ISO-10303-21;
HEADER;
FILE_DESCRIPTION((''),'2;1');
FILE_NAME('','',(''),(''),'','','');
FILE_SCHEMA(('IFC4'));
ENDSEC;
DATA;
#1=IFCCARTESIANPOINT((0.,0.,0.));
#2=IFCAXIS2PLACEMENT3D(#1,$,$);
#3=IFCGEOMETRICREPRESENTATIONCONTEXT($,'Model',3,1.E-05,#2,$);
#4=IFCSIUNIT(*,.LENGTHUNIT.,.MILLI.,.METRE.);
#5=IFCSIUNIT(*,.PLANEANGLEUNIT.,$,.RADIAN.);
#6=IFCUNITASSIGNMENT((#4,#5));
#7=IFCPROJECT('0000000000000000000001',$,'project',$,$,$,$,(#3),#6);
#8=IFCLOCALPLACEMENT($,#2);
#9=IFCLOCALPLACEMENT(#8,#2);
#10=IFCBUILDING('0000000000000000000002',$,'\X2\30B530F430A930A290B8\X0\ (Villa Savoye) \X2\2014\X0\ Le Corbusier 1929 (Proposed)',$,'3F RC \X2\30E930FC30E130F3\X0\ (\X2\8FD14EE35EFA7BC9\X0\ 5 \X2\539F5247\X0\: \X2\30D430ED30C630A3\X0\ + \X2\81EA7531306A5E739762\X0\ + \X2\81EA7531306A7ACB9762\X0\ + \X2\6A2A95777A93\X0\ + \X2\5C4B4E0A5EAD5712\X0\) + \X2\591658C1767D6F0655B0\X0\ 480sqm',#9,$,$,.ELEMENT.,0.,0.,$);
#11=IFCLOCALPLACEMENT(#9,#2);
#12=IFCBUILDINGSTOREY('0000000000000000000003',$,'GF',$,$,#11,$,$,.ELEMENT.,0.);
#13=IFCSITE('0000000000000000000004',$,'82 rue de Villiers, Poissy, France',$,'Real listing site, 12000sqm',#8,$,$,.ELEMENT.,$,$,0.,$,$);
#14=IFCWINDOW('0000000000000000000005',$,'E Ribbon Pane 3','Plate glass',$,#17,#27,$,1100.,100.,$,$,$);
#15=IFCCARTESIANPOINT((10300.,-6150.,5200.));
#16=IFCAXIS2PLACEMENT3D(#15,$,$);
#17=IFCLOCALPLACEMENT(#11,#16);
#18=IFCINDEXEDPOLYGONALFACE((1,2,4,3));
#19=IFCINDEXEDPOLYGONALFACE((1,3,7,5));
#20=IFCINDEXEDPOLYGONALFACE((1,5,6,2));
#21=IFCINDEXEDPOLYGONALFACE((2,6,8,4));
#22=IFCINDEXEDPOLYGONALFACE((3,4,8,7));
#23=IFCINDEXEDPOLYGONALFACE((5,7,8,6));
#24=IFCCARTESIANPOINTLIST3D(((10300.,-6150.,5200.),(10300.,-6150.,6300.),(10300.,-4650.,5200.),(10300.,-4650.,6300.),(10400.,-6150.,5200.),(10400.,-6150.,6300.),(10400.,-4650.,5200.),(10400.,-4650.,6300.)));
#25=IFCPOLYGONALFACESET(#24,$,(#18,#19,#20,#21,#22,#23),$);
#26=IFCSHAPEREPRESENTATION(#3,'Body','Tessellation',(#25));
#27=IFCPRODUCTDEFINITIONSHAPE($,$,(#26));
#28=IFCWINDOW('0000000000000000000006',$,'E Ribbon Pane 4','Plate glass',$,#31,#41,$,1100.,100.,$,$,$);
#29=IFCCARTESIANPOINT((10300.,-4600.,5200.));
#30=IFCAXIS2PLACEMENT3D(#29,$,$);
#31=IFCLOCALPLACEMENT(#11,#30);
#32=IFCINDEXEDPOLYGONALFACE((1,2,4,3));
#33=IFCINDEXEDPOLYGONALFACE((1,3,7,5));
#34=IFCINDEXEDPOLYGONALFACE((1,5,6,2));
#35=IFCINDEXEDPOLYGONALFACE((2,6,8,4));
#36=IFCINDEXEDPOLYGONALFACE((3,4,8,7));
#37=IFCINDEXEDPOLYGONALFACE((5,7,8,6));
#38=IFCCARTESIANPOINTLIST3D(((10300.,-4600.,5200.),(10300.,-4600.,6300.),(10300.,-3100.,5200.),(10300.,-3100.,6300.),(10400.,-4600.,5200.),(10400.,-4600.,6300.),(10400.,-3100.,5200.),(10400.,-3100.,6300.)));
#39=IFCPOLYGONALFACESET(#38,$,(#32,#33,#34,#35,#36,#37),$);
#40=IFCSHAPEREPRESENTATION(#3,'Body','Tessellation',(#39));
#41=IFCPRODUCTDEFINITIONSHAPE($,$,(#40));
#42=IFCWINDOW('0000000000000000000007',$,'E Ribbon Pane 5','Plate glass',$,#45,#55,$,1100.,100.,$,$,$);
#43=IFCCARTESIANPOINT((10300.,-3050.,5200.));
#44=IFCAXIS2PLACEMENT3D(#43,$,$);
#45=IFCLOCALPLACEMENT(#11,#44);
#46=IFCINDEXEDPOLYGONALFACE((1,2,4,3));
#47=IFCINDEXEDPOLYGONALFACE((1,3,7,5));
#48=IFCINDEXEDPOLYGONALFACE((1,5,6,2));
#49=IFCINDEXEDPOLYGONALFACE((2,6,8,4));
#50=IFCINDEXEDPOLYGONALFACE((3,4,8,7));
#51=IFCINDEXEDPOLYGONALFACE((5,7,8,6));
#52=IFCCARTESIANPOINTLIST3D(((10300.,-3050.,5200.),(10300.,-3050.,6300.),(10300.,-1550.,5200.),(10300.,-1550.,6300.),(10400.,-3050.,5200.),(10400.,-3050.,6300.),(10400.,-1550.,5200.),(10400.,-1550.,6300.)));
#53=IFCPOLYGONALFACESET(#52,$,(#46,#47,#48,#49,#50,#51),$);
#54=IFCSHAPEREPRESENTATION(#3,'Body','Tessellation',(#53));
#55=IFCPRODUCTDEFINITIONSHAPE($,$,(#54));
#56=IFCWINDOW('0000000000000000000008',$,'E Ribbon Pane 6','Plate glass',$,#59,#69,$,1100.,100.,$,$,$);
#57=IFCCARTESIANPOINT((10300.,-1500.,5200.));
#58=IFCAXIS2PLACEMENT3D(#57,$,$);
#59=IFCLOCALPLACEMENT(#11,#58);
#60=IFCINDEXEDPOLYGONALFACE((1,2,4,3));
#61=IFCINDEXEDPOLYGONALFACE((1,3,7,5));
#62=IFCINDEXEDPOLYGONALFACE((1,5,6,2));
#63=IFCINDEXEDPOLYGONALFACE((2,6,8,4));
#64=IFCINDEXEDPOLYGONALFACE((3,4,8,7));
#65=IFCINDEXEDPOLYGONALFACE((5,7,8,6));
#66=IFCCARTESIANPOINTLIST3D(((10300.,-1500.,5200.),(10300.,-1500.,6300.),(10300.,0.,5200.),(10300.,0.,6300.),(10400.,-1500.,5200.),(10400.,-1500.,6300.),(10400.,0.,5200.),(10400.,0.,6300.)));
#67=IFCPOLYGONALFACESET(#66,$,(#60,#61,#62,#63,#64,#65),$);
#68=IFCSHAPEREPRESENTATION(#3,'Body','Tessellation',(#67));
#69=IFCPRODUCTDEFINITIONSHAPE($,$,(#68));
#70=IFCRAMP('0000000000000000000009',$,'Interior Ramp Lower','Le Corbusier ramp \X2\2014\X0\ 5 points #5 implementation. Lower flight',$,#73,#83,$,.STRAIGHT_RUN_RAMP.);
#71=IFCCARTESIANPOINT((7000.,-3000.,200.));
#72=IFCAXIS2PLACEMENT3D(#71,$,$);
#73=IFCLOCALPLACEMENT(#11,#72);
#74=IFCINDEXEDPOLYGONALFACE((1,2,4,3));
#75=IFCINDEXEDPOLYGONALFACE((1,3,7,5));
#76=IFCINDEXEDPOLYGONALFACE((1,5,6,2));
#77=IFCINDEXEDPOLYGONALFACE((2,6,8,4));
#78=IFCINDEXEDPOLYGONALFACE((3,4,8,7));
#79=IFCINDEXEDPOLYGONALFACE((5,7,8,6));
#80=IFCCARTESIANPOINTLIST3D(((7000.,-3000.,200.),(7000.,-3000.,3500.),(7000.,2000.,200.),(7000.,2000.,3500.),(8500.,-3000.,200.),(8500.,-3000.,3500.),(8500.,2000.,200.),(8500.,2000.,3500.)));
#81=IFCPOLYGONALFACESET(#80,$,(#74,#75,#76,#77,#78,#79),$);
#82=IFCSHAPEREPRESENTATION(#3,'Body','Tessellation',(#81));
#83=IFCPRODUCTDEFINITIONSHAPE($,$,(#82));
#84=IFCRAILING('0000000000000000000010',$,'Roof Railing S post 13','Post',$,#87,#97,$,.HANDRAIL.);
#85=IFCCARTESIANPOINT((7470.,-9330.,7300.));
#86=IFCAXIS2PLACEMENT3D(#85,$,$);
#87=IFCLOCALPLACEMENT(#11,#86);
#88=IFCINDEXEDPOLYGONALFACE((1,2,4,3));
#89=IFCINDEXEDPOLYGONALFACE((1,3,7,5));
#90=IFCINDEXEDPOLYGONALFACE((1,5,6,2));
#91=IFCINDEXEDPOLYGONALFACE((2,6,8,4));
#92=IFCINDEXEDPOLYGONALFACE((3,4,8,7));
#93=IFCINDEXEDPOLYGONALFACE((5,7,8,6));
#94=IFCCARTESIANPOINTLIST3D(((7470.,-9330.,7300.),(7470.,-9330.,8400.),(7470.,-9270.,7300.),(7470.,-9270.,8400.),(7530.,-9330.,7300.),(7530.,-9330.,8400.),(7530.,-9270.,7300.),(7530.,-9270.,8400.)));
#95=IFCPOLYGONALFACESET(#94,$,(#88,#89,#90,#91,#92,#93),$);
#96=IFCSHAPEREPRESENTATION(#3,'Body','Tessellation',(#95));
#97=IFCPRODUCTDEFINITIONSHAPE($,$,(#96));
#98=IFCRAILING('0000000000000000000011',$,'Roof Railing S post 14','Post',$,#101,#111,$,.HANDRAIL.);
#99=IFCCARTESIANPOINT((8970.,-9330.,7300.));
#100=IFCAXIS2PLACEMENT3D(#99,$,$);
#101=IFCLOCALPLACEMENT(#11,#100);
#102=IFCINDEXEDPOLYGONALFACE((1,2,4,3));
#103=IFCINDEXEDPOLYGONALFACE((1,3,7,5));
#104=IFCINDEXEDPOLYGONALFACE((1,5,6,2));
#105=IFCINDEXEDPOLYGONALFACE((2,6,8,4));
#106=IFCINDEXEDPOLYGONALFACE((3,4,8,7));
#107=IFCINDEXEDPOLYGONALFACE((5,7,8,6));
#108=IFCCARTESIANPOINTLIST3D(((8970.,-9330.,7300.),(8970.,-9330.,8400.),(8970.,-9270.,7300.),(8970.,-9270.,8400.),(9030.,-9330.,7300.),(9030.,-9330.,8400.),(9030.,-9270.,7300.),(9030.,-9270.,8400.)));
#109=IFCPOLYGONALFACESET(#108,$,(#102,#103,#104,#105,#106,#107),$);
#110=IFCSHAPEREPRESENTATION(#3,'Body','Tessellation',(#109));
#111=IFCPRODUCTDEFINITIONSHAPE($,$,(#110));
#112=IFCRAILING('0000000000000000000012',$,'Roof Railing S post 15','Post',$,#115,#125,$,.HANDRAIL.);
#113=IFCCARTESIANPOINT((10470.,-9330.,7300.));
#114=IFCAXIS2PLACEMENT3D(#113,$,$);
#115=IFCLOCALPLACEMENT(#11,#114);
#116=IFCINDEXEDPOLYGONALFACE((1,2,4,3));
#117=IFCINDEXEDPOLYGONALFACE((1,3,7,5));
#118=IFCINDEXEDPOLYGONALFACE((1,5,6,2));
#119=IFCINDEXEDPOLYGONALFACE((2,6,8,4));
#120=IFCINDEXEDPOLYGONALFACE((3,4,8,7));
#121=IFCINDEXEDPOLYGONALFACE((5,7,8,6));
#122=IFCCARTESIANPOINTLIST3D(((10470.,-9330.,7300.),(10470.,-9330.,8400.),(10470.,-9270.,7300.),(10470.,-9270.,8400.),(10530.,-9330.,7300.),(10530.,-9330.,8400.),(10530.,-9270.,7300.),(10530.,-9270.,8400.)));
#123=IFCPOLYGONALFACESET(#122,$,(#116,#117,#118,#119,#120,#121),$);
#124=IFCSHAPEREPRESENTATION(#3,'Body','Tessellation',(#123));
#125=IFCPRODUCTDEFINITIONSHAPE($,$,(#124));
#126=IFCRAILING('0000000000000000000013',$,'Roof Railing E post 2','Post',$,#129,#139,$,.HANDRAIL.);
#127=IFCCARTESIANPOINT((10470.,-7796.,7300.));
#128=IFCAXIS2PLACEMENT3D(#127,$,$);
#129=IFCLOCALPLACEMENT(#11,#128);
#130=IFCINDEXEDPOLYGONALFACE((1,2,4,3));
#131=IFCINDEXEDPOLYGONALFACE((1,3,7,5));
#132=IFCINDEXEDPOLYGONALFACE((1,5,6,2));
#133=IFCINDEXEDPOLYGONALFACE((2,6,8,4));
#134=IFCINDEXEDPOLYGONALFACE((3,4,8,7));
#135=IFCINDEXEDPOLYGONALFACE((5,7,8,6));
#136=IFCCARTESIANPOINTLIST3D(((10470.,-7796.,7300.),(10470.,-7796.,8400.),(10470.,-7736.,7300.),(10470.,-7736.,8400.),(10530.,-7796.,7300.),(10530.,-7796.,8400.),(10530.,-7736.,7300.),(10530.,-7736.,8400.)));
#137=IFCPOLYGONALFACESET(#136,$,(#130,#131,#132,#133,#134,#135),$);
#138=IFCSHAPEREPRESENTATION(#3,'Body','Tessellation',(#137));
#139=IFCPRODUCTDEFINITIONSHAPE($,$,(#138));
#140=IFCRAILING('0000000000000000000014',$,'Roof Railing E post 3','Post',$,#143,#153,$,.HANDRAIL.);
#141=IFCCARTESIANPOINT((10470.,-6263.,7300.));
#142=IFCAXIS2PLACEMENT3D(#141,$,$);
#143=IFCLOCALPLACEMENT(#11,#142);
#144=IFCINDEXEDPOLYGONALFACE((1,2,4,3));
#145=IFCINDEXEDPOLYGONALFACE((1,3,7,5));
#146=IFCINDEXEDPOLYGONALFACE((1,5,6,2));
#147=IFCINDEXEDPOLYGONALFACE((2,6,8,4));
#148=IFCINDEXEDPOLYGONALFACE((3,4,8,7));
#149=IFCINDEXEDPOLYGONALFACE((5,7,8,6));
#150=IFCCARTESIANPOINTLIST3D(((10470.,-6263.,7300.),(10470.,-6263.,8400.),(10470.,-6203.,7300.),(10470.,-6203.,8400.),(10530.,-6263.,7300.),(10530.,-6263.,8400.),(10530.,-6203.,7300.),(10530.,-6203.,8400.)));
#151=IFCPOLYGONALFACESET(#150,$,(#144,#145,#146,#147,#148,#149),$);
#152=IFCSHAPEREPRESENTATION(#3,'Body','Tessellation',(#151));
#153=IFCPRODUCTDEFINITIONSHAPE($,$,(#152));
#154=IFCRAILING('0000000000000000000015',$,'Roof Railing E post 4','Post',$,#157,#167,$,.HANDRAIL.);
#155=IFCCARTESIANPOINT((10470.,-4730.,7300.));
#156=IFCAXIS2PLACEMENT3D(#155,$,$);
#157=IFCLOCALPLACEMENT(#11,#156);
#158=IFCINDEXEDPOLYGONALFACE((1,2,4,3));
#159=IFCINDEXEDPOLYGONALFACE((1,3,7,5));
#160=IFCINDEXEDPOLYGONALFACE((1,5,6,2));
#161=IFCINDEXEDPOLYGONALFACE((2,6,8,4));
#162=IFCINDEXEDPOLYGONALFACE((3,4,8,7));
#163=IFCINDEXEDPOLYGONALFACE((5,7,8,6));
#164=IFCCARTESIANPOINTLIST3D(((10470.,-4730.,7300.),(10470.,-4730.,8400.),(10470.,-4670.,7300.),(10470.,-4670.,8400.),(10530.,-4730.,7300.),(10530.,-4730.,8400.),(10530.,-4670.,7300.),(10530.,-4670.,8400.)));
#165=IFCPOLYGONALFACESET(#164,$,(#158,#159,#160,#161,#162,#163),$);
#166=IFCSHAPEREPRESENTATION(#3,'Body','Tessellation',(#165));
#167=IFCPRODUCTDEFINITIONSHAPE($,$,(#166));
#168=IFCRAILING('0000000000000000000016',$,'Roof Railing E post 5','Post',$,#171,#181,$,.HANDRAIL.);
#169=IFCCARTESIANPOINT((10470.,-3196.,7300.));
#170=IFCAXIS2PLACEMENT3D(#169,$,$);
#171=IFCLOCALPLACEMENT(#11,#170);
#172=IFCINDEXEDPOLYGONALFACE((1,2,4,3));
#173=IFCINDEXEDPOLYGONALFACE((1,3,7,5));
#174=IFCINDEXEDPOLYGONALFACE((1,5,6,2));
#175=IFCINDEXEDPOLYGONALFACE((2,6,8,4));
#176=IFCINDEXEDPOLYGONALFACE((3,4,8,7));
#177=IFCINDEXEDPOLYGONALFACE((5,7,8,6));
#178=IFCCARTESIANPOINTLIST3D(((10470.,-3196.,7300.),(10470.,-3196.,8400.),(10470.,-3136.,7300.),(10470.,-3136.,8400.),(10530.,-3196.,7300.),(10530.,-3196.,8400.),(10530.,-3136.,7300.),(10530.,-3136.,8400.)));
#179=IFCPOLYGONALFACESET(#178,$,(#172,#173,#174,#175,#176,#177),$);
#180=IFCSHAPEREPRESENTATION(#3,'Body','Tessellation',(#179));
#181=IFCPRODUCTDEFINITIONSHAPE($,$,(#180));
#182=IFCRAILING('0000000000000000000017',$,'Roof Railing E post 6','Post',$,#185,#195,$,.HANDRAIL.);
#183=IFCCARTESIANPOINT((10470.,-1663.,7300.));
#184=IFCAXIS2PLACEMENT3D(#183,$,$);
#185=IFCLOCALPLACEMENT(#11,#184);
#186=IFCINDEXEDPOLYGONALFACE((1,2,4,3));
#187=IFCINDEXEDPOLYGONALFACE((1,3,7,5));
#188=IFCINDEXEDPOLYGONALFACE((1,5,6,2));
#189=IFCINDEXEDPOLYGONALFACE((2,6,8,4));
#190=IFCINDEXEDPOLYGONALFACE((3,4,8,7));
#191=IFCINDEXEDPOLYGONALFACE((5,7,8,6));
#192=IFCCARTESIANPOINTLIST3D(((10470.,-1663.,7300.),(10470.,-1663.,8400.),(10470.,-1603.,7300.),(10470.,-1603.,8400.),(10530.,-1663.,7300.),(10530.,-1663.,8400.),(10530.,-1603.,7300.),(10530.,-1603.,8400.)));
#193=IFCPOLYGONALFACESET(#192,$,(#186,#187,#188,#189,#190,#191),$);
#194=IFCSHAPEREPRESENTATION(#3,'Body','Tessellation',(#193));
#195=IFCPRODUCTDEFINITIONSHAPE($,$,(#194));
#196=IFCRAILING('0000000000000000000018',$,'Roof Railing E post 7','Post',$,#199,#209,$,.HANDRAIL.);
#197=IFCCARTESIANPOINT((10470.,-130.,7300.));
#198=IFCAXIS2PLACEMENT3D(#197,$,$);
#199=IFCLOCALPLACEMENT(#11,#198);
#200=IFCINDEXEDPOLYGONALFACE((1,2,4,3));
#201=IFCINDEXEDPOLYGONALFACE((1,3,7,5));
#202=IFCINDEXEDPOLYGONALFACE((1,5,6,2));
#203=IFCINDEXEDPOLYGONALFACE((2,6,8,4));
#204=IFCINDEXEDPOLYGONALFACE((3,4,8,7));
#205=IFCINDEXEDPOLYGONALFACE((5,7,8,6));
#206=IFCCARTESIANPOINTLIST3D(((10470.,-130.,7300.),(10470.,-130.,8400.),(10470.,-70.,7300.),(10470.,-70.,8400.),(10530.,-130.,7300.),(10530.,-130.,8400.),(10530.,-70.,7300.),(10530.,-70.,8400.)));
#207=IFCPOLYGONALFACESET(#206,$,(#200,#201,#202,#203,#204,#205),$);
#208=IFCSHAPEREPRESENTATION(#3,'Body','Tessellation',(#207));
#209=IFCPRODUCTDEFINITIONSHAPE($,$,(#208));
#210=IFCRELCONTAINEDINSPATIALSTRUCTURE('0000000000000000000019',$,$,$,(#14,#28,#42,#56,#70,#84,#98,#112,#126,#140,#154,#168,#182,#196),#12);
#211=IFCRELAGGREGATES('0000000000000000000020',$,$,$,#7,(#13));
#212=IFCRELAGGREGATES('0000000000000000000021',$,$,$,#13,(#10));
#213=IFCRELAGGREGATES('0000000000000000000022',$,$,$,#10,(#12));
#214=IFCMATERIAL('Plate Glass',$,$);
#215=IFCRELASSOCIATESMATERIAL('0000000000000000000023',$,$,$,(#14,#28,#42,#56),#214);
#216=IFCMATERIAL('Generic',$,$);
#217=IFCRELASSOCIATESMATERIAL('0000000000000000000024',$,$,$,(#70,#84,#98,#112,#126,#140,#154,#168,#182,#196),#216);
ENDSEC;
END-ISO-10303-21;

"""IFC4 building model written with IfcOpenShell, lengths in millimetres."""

from ifc_helpers import new_model, si_unit, frame, frame_2d, origin, place, context, project, spatial, rectangle, extrude, material, element, save


model = new_model("IFC4")

# Units and contexts
model_context = context("Model", 3, precision=1e-05, world=origin())
ifc_project = project(units=[si_unit("LENGTHUNIT", "METRE", prefix="MILLI"), si_unit("PLANEANGLEUNIT", "RADIAN")], contexts=[model_context])

# Site, building, storey
site_placement = place(None, origin())
site = spatial("IfcSite", under=ifc_project, at=site_placement, Name="82 rue de Villiers, Poissy, France", ObjectType="Real listing site, 12000sqm", CompositionType="ELEMENT", RefElevation=0.0)
building_placement = place(site_placement, origin())
building = spatial("IfcBuilding", under=site, at=building_placement, Name="サヴォア邸 (Villa Savoye) — Le Corbusier 1929 (Proposed)", ObjectType="3F RC ラーメン (近代建築 5 原則: ピロティ + 自由な平面 + 自由な立面 + 横長窓 + 屋上庭園) + 外壁白漆喰 480sqm", CompositionType="ELEMENT", ElevationOfRefHeight=0.0, ElevationOfTerrain=0.0)
storey_placement = place(building_placement, origin())
storey = spatial("IfcBuildingStorey", under=building, at=storey_placement, Name="GF", CompositionType="ELEMENT", Elevation=0.0)

# Shared definitions
ifc_material_1 = material(Name="Generic")

# Windows
ifc_material_2 = material(Name="Plate Glass")
window_1_placement = place(storey_placement, frame((10300.0, -6150.0, 5200.0)))
element("IfcWindow", 1, at=window_1_placement, inside=storey, material=ifc_material_2, Name="E Ribbon Pane 3", Description="Plate glass", OverallHeight=1100.0, OverallWidth=100.0, context=model_context, shape_type="SweptSolid", body=[
    extrude(rectangle(XDim=100.0, YDim=1500.0, at=frame_2d((50.0, 750.0))), frame((10300.0, -6150.0, 5200.0)), (0.0, 0.0, 1.0), 1100.0),
])
window_2_placement = place(storey_placement, frame((10300.0, -4600.0, 5200.0)))
element("IfcWindow", 2, at=window_2_placement, inside=storey, material=ifc_material_2, Name="E Ribbon Pane 4", Description="Plate glass", OverallHeight=1100.0, OverallWidth=100.0, context=model_context, shape_type="SweptSolid", body=[
    extrude(rectangle(XDim=100.0, YDim=1500.0, at=frame_2d((50.0, 750.0))), frame((10300.0, -4600.0, 5200.0)), (0.0, 0.0, 1.0), 1100.0),
])
window_3_placement = place(storey_placement, frame((10300.0, -3050.0, 5200.0)))
element("IfcWindow", 3, at=window_3_placement, inside=storey, material=ifc_material_2, Name="E Ribbon Pane 5", Description="Plate glass", OverallHeight=1100.0, OverallWidth=100.0, context=model_context, shape_type="SweptSolid", body=[
    extrude(rectangle(XDim=100.0, YDim=1500.0, at=frame_2d((50.0, 750.0))), frame((10300.0, -3050.0, 5200.0)), (0.0, 0.0, 1.0), 1100.0),
])
window_4_placement = place(storey_placement, frame((10300.0, -1500.0, 5200.0)))
element("IfcWindow", 4, at=window_4_placement, inside=storey, material=ifc_material_2, Name="E Ribbon Pane 6", Description="Plate glass", OverallHeight=1100.0, OverallWidth=100.0, context=model_context, shape_type="SweptSolid", body=[
    extrude(rectangle(XDim=100.0, YDim=1500.0, at=frame_2d((50.0, 750.0))), frame((10300.0, -1500.0, 5200.0)), (0.0, 0.0, 1.0), 1100.0),
])

# Ramp
ramp_placement = place(storey_placement, frame((7000.0, -3000.0, 200.0)))
element("IfcRamp", 5, at=ramp_placement, inside=storey, material=ifc_material_1, Name="Interior Ramp Lower", Description="Le Corbusier ramp — 5 points #5 implementation. Lower flight", PredefinedType="STRAIGHT_RUN_RAMP", context=model_context, shape_type="SweptSolid", body=[
    extrude(rectangle(XDim=1500.0, YDim=5000.0, at=frame_2d((750.0, 2500.0))), frame((7000.0, -3000.0, 200.0)), (0.0, 0.0, 1.0), 3300.0),
])

# Railings
railing_1_placement = place(storey_placement, frame((7470.0, -9330.0, 7300.0)))
element("IfcRailing", 6, at=railing_1_placement, inside=storey, material=ifc_material_1, Name="Roof Railing S post 13", Description="Post", PredefinedType="HANDRAIL", context=model_context, shape_type="SweptSolid", body=[
    extrude(rectangle(XDim=60.0, YDim=60.0, at=frame_2d((30.0, 30.0))), frame((7470.0, -9330.0, 7300.0)), (0.0, 0.0, 1.0), 1100.0),
])
railing_2_placement = place(storey_placement, frame((8970.0, -9330.0, 7300.0)))
element("IfcRailing", 7, at=railing_2_placement, inside=storey, material=ifc_material_1, Name="Roof Railing S post 14", Description="Post", PredefinedType="HANDRAIL", context=model_context, shape_type="SweptSolid", body=[
    extrude(rectangle(XDim=60.0, YDim=60.0, at=frame_2d((30.0, 30.0))), frame((8970.0, -9330.0, 7300.0)), (0.0, 0.0, 1.0), 1100.0),
])
for number, where, name in (
    (8, (10470.0, -9330.0, 7300.0), "Roof Railing S post 15"),
):
    element("IfcRailing", number, at=place(storey_placement, frame(where)), inside=storey, material=ifc_material_1, Name=name, Description="Post", PredefinedType="HANDRAIL", context=model_context, shape_type="SweptSolid", body=[
        extrude(rectangle(XDim=60.0, YDim=60.0, at=frame_2d((30.0, 30.0))), frame((10470.0, -9330.0, 7300.0)), (0.0, 0.0, 1.0), 1100.0),
    ])
railing_3_placement = place(storey_placement, frame((10470.0, -7796.0, 7300.0)))
element("IfcRailing", 9, at=railing_3_placement, inside=storey, material=ifc_material_1, Name="Roof Railing E post 2", Description="Post", PredefinedType="HANDRAIL", context=model_context, shape_type="SweptSolid", body=[
    extrude(rectangle(XDim=60.0, YDim=60.0, at=frame_2d((30.0, 30.0))), frame((10470.0, -7796.0, 7300.0)), (0.0, 0.0, 1.0), 1100.0),
])
railing_4_placement = place(storey_placement, frame((10470.0, -6263.0, 7300.0)))
element("IfcRailing", 10, at=railing_4_placement, inside=storey, material=ifc_material_1, Name="Roof Railing E post 3", Description="Post", PredefinedType="HANDRAIL", context=model_context, shape_type="SweptSolid", body=[
    extrude(rectangle(XDim=60.0, YDim=60.0, at=frame_2d((30.0, 30.0))), frame((10470.0, -6263.0, 7300.0)), (0.0, 0.0, 1.0), 1100.0),
])
railing_5_placement = place(storey_placement, frame((10470.0, -4730.0, 7300.0)))
element("IfcRailing", 11, at=railing_5_placement, inside=storey, material=ifc_material_1, Name="Roof Railing E post 4", Description="Post", PredefinedType="HANDRAIL", context=model_context, shape_type="SweptSolid", body=[
    extrude(rectangle(XDim=60.0, YDim=60.0, at=frame_2d((30.0, 30.0))), frame((10470.0, -4730.0, 7300.0)), (0.0, 0.0, 1.0), 1100.0),
])
railing_6_placement = place(storey_placement, frame((10470.0, -3196.0, 7300.0)))
element("IfcRailing", 12, at=railing_6_placement, inside=storey, material=ifc_material_1, Name="Roof Railing E post 5", Description="Post", PredefinedType="HANDRAIL", context=model_context, shape_type="SweptSolid", body=[
    extrude(rectangle(XDim=60.0, YDim=60.0, at=frame_2d((30.0, 30.0))), frame((10470.0, -3196.0, 7300.0)), (0.0, 0.0, 1.0), 1100.0),
])
railing_7_placement = place(storey_placement, frame((10470.0, -1663.0, 7300.0)))
element("IfcRailing", 13, at=railing_7_placement, inside=storey, material=ifc_material_1, Name="Roof Railing E post 6", Description="Post", PredefinedType="HANDRAIL", context=model_context, shape_type="SweptSolid", body=[
    extrude(rectangle(XDim=60.0, YDim=60.0, at=frame_2d((30.0, 30.0))), frame((10470.0, -1663.0, 7300.0)), (0.0, 0.0, 1.0), 1100.0),
])
railing_8_placement = place(storey_placement, frame((10470.0, -130.0, 7300.0)))
element("IfcRailing", 14, at=railing_8_placement, inside=storey, material=ifc_material_1, Name="Roof Railing E post 7", Description="Post", PredefinedType="HANDRAIL", context=model_context, shape_type="SweptSolid", body=[
    extrude(rectangle(XDim=60.0, YDim=60.0, at=frame_2d((30.0, 30.0))), frame((10470.0, -130.0, 7300.0)), (0.0, 0.0, 1.0), 1100.0),
])

save(model, "model.ifc")
